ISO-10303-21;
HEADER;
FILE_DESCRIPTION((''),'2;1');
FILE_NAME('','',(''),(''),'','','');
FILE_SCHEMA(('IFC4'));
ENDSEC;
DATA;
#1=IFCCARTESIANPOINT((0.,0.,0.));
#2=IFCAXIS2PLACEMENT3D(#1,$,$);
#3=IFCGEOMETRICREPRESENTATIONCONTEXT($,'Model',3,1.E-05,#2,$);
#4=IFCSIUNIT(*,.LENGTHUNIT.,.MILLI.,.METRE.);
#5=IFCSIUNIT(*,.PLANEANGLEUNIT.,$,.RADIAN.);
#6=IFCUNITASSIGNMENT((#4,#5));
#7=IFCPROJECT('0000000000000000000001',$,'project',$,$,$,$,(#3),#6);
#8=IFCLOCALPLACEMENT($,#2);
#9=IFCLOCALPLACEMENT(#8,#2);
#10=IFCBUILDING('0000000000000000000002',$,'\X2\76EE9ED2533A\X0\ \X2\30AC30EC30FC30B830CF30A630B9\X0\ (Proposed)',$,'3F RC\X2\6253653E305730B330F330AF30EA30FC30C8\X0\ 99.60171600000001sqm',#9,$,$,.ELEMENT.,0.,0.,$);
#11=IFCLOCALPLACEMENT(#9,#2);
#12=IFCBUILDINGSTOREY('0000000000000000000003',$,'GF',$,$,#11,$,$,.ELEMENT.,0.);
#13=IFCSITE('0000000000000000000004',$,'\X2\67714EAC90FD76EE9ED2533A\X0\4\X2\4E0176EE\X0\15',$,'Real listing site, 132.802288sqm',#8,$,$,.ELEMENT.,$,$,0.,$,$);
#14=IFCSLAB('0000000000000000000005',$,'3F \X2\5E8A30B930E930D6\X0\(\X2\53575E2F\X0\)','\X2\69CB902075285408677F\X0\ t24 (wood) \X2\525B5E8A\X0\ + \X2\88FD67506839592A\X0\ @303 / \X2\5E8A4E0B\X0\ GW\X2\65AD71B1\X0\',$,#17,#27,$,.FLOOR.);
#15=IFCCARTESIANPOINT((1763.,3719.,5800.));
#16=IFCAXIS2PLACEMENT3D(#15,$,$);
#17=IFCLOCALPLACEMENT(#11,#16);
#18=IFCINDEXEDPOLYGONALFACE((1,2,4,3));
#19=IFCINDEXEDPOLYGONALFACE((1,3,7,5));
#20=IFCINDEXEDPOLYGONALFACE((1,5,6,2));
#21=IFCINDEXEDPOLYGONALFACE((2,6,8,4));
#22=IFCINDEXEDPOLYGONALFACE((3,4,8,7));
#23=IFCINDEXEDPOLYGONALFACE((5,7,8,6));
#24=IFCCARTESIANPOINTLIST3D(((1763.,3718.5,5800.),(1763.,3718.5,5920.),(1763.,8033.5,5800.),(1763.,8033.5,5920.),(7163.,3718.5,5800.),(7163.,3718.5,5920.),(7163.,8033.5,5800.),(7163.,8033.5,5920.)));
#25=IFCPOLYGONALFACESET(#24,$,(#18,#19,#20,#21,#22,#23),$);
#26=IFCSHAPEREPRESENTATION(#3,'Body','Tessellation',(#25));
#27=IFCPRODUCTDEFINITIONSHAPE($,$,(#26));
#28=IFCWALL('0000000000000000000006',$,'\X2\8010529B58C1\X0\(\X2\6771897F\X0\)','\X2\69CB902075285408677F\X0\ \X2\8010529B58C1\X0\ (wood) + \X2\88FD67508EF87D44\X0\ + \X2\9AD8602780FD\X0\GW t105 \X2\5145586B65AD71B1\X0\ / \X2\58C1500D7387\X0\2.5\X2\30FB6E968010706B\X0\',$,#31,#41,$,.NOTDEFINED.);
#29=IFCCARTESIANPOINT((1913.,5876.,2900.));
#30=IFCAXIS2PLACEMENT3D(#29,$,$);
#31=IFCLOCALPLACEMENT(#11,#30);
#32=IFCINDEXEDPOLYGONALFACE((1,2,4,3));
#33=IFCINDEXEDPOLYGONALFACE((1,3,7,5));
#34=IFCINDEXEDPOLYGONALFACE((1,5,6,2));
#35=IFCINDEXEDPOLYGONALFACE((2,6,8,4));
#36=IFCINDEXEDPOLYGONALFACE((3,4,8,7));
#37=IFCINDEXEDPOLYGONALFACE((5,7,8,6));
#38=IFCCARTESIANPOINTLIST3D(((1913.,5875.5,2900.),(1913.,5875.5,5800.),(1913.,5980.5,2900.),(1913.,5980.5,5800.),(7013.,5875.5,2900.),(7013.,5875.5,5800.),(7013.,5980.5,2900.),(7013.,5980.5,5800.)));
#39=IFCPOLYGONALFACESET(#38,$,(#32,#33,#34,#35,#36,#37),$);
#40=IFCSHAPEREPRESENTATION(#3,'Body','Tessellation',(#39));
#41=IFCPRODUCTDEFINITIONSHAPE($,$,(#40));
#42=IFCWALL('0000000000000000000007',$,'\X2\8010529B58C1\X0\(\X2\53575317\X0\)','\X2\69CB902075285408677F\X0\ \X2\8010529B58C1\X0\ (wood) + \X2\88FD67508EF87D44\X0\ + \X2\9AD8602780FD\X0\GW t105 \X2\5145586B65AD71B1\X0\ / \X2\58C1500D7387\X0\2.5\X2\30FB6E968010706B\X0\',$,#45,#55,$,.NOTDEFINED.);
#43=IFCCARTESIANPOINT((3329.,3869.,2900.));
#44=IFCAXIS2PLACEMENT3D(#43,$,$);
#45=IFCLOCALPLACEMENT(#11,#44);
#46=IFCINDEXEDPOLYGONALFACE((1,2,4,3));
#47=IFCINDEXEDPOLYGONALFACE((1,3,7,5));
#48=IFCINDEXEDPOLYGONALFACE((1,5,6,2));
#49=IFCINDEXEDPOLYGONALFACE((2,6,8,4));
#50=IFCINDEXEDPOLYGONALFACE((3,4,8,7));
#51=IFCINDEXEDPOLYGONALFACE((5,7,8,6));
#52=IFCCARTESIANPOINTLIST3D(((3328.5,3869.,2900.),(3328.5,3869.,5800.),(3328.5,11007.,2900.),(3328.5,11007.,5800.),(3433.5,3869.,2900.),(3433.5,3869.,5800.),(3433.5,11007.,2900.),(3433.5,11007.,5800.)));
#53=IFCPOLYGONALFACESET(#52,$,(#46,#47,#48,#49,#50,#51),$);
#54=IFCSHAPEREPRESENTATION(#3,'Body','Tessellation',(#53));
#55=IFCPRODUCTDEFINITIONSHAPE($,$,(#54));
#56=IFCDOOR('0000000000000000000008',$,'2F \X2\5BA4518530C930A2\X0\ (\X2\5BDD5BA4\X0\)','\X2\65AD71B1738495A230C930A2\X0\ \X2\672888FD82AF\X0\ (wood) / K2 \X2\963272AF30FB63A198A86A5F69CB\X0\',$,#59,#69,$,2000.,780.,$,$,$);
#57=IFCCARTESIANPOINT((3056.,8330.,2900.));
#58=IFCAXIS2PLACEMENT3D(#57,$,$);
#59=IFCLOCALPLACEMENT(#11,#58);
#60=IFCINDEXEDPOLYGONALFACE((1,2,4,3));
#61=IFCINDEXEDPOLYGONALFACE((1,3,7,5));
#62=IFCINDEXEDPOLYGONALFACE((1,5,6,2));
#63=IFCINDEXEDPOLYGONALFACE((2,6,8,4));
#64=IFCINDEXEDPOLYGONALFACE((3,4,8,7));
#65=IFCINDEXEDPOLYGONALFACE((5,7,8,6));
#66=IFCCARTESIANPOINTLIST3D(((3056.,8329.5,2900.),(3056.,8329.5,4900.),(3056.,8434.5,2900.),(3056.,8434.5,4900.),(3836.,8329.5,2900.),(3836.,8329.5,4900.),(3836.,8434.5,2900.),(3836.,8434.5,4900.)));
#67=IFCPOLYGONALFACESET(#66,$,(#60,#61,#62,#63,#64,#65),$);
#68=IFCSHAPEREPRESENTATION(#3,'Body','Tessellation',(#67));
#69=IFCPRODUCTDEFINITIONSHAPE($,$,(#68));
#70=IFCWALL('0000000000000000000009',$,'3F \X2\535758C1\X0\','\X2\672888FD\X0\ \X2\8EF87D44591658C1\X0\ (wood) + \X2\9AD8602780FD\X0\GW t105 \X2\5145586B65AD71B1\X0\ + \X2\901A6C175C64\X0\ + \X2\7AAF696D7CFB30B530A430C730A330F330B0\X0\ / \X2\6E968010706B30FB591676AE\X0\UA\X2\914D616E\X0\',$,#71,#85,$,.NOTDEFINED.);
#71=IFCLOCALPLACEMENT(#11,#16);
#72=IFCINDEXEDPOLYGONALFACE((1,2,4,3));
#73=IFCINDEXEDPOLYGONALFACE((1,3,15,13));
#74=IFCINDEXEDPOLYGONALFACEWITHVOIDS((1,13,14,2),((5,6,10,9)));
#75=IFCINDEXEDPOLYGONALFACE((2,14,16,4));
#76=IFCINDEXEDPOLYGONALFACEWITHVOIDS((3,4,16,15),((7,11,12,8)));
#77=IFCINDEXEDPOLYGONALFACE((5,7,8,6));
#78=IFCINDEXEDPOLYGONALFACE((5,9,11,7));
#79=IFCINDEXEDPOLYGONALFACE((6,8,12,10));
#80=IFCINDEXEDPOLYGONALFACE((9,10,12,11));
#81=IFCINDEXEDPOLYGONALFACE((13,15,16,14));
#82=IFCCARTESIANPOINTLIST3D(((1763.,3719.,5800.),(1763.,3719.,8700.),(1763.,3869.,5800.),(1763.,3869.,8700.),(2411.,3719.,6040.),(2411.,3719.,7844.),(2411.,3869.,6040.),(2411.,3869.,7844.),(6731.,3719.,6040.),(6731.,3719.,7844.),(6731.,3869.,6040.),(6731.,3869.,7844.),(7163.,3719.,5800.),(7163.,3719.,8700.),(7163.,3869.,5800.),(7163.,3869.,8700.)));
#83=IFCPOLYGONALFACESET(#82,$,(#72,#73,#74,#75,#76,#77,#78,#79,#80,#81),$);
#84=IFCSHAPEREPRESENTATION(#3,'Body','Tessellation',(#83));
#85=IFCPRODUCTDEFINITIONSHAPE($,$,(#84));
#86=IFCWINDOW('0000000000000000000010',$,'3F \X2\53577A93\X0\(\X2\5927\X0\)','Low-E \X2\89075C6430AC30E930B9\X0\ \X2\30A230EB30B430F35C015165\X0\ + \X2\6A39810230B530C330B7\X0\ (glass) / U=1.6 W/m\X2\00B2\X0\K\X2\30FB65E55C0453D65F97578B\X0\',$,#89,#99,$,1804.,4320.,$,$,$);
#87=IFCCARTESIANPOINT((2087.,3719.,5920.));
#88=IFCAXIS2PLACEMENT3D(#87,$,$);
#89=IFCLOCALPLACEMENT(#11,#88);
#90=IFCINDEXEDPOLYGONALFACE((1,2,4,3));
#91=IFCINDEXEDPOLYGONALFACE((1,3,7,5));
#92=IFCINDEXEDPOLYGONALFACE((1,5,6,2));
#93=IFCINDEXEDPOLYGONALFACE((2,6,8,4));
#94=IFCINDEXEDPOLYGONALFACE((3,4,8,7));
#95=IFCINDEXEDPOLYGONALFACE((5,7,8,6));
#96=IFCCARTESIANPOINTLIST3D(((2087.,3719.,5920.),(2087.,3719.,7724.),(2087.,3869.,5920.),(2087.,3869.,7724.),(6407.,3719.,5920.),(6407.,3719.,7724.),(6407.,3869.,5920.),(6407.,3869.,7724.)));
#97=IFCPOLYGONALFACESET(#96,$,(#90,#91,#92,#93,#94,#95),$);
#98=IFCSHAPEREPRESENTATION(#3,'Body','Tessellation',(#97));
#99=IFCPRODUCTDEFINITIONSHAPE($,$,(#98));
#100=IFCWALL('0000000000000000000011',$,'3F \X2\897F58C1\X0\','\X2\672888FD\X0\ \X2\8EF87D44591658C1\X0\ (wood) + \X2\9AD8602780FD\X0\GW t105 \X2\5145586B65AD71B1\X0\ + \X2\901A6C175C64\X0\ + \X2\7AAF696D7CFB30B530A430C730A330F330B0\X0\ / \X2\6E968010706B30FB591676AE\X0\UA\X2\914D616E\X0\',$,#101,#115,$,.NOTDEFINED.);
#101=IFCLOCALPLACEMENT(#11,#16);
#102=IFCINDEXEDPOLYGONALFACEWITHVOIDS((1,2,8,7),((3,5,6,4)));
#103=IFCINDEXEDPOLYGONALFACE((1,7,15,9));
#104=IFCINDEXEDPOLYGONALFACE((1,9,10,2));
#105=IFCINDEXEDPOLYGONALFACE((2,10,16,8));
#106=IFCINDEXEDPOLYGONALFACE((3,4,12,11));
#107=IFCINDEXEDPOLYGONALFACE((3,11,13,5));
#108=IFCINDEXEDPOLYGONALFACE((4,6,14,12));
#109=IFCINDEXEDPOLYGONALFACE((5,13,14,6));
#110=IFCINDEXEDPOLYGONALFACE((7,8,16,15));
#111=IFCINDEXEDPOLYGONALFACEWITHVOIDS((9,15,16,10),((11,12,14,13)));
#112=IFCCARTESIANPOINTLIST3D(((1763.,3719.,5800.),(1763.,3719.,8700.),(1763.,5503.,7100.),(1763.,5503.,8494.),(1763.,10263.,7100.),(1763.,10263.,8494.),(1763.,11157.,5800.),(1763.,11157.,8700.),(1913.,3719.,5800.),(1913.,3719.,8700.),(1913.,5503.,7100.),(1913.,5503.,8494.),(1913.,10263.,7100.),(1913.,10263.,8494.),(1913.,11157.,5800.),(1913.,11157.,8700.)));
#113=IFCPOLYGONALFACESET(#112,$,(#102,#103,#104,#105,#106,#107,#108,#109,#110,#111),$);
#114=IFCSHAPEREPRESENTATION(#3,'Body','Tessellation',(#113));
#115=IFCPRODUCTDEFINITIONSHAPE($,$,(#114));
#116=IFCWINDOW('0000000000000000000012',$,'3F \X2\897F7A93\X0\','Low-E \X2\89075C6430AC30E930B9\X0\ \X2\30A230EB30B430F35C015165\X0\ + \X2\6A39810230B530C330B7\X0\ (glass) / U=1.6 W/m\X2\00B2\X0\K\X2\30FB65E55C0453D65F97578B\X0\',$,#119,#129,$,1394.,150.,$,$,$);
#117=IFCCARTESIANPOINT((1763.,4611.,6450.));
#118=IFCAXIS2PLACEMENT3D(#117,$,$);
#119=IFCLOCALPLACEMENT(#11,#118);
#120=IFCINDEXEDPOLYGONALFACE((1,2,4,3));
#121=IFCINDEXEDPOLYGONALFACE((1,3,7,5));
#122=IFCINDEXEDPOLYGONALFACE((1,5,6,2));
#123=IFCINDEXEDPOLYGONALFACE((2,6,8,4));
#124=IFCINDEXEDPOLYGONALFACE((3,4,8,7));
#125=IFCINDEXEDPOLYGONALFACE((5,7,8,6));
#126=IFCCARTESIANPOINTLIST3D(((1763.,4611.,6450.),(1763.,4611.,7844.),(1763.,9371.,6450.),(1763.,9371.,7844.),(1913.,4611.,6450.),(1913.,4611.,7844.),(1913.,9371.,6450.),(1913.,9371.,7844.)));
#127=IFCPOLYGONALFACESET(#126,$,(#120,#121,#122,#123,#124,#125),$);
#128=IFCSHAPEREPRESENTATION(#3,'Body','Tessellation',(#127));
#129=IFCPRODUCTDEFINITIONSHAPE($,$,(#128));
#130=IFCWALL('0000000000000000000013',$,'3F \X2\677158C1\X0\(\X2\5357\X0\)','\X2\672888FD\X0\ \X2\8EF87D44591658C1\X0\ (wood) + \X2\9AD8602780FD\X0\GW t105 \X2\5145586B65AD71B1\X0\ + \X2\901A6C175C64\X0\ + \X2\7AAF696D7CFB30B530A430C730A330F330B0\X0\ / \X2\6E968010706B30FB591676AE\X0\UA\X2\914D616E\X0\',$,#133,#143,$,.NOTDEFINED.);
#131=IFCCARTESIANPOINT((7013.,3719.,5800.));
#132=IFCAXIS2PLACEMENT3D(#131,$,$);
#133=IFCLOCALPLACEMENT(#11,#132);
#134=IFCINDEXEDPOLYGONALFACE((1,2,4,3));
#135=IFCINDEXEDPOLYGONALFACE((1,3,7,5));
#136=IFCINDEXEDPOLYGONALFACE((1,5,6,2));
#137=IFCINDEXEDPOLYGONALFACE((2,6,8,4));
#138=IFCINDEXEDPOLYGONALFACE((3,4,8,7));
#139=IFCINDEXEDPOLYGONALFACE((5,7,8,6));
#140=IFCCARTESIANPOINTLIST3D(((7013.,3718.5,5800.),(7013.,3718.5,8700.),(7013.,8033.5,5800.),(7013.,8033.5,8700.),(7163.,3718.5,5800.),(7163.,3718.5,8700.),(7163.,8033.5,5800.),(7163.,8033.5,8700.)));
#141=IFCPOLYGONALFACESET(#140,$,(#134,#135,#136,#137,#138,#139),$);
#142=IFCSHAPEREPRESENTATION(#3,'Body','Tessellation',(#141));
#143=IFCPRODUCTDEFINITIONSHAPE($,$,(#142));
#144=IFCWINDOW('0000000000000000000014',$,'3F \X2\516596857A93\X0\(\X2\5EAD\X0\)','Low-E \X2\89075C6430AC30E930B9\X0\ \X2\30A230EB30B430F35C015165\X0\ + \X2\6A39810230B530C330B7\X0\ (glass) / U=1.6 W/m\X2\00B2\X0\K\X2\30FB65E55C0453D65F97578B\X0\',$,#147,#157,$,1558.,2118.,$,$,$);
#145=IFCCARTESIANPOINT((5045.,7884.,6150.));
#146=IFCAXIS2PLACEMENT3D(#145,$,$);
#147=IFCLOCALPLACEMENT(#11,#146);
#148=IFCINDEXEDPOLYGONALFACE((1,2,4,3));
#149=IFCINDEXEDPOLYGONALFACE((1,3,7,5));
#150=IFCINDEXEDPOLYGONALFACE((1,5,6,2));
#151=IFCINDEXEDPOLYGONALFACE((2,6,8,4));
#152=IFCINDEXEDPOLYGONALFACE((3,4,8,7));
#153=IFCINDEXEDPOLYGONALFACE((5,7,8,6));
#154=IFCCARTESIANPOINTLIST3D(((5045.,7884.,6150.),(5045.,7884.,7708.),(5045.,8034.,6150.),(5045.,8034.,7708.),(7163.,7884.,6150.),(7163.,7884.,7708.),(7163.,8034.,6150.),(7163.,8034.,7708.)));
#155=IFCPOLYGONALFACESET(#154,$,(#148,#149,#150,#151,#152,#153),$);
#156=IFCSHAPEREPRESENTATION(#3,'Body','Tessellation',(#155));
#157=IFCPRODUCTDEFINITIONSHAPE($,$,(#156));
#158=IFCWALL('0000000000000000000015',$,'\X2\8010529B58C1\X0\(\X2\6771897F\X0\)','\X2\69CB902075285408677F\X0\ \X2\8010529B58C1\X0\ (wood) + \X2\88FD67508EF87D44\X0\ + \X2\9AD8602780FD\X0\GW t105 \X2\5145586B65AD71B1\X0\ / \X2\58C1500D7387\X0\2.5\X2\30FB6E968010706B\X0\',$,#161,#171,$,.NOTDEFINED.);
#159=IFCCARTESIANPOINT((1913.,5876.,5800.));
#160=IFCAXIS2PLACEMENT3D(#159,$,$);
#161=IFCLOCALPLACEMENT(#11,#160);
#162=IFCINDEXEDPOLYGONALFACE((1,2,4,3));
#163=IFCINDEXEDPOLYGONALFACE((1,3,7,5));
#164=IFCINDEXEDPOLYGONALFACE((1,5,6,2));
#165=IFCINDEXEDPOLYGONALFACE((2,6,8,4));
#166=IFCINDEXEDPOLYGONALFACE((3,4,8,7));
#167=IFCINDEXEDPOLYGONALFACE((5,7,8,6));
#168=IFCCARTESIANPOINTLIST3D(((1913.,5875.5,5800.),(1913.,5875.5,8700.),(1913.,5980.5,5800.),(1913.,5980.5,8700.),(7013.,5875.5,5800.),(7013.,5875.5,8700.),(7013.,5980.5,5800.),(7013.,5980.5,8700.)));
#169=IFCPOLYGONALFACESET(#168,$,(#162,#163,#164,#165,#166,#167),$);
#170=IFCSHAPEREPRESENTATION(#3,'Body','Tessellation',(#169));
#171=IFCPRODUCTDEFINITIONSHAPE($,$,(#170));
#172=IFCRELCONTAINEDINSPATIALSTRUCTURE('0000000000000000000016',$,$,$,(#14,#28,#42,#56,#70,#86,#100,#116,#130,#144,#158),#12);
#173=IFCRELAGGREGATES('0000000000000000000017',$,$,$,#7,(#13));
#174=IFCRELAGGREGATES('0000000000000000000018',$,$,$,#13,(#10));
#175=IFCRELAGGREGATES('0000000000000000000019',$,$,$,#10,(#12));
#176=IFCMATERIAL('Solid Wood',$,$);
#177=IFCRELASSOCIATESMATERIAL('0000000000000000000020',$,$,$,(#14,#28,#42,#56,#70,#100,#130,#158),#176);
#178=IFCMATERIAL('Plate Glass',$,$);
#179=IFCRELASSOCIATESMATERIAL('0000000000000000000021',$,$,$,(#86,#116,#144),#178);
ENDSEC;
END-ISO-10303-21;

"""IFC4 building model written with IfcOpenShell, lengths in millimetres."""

from ifc_helpers import new_model, si_unit, frame, frame_2d, origin, place, context, project, spatial, rectangle, extrude, material, element, fill, save


model = new_model("IFC4")

# Units and contexts
model_context = context("Model", 3, precision=1e-05, world=origin())
ifc_project = project(units=[si_unit("LENGTHUNIT", "METRE", prefix="MILLI"), si_unit("PLANEANGLEUNIT", "RADIAN")], contexts=[model_context])

# Site, building, storey
site_placement = place(None, origin())
site = spatial("IfcSite", under=ifc_project, at=site_placement, Name="東京都目黒区4丁目15", ObjectType="Real listing site, 132.802288sqm", CompositionType="ELEMENT", RefElevation=0.0)
building_placement = place(site_placement, origin())
building = spatial("IfcBuilding", under=site, at=building_placement, Name="目黒区 ガレージハウス (Proposed)", ObjectType="3F RC打放しコンクリート 99.60171600000001sqm", CompositionType="ELEMENT", ElevationOfRefHeight=0.0, ElevationOfTerrain=0.0)
storey_placement = place(building_placement, origin())
storey = spatial("IfcBuildingStorey", under=building, at=storey_placement, Name="GF", CompositionType="ELEMENT", Elevation=0.0)

# Slab
ifc_material_1 = material(Name="Solid Wood")
slab_placement = place(storey_placement, frame((1763.0, 3719.0, 5800.0)))
element("IfcSlab", 1, at=slab_placement, inside=storey, material=ifc_material_1, Name="3F 床スラブ(南帯)", Description="構造用合板 t24 (wood) 剛床 + 製材根太 @303 / 床下 GW断熱", PredefinedType="FLOOR", context=model_context, shape_type="SweptSolid", body=[
    extrude(rectangle(XDim=5400.0, YDim=4315.0, at=frame_2d((2700.0, 2157.0))), frame((1763.0, 3719.0, 5800.0)), (0.0, 0.0, 1.0), 120.0),
])

# Wall
wall_1_placement = place(storey_placement, frame((1913.0, 5876.0, 2900.0)))
element("IfcWall", 2, at=wall_1_placement, inside=storey, material=ifc_material_1, Name="耐力壁(東西)", Description="構造用合板 耐力壁 (wood) + 製材軸組 + 高性能GW t105 充填断熱 / 壁倍率2.5・準耐火", PredefinedType="NOTDEFINED", context=model_context, shape_type="SweptSolid", body=[
    extrude(rectangle(XDim=5100.0, YDim=105.0, at=frame_2d((2550.0, 52.0))), frame((1913.0, 5876.0, 2900.0)), (0.0, 0.0, 1.0), 2900.0),
])

# Wall, opening, door
wall_2_placement = place(storey_placement, frame((3329.0, 3869.0, 2900.0)))
wall_2 = element("IfcWall", 3, at=wall_2_placement, inside=storey, material=ifc_material_1, Name="耐力壁(南北)", Description="構造用合板 耐力壁 (wood) + 製材軸組 + 高性能GW t105 充填断熱 / 壁倍率2.5・準耐火", PredefinedType="NOTDEFINED", context=model_context, shape_type="SweptSolid", body=[
    extrude(rectangle(XDim=105.0, YDim=7138.0, at=frame_2d((52.0, 3569.0))), frame((3329.0, 3869.0, 2900.0)), (0.0, 0.0, 1.0), 2900.0),
])
opening_1_placement = place(storey_placement, frame((3056.0, 8330.0, 2900.0)))
opening_1 = element("IfcOpeningElement", 4, at=opening_1_placement, cuts=wall_2, PredefinedType="NOTDEFINED", context=model_context, shape_type="SweptSolid", body=[
    extrude(rectangle(XDim=780.0, YDim=105.0, at=frame_2d((390.0, 52.0))), frame((3056.0, 8330.0, 2900.0)), (0.0, 0.0, 1.0), 2000.0),
])
door_1_placement = place(storey_placement, frame((3056.0, 8330.0, 2900.0)))
door_1 = element("IfcDoor", 5, at=door_1_placement, inside=storey, material=ifc_material_1, Name="2F 室内ドア (寝室)", Description="断熱玄関ドア 木製芯 (wood) / K2 防犯・採風機構", OverallHeight=2000.0, OverallWidth=780.0, context=model_context, shape_type="SweptSolid", body=[
    extrude(rectangle(XDim=780.0, YDim=105.0, at=frame_2d((390.0, 52.0))), frame((3056.0, 8330.0, 2900.0)), (0.0, 0.0, 1.0), 2000.0),
])
fill(opening_1, door_1)

# Walls, openings, windows
wall_3_placement = place(storey_placement, frame((1763.0, 3719.0, 5800.0)))
wall_3 = element("IfcWall", 6, at=wall_3_placement, inside=storey, material=ifc_material_1, Name="3F 南壁", Description="木製 軸組外壁 (wood) + 高性能GW t105 充填断熱 + 通気層 + 窯業系サイディング / 準耐火・外皮UA配慮", PredefinedType="NOTDEFINED", context=model_context, shape_type="SweptSolid", body=[
    extrude(rectangle(XDim=5400.0, YDim=150.0, at=frame_2d((2700.0, 75.0))), frame((1763.0, 3719.0, 5800.0)), (0.0, 0.0, 1.0), 2900.0),
])
opening_2_placement = place(storey_placement, frame((2087.0, 3719.0, 5920.0)))
opening_2 = element("IfcOpeningElement", 7, at=opening_2_placement, cuts=wall_3, PredefinedType="NOTDEFINED", context=model_context, shape_type="SweptSolid", body=[
    extrude(rectangle(XDim=4320.0, YDim=150.0, at=frame_2d((2160.0, 75.0))), frame((2087.0, 3719.0, 5920.0)), (0.0, 0.0, 1.0), 1804.0),
])
ifc_material_2 = material(Name="Plate Glass")
window_1_placement = place(storey_placement, frame((2087.0, 3719.0, 5920.0)))
window_1 = element("IfcWindow", 8, at=window_1_placement, inside=storey, material=ifc_material_2, Name="3F 南窓(大)", Description="Low-E 複層ガラス アルゴン封入 + 樹脂サッシ (glass) / U=1.6 W/m²K・日射取得型", OverallHeight=1804.0, OverallWidth=4320.0, context=model_context, shape_type="SweptSolid", body=[
    extrude(rectangle(XDim=4320.0, YDim=150.0, at=frame_2d((2160.0, 75.0))), frame((2087.0, 3719.0, 5920.0)), (0.0, 0.0, 1.0), 1804.0),
])
fill(opening_2, window_1)
wall_4_placement = place(storey_placement, frame((1763.0, 3719.0, 5800.0)))
wall_4 = element("IfcWall", 9, at=wall_4_placement, inside=storey, material=ifc_material_1, Name="3F 西壁", Description="木製 軸組外壁 (wood) + 高性能GW t105 充填断熱 + 通気層 + 窯業系サイディング / 準耐火・外皮UA配慮", PredefinedType="NOTDEFINED", context=model_context, shape_type="SweptSolid", body=[
    extrude(rectangle(XDim=150.0, YDim=7438.0, at=frame_2d((75.0, 3719.0))), frame((1763.0, 3719.0, 5800.0)), (0.0, 0.0, 1.0), 2900.0),
])
opening_3_placement = place(storey_placement, frame((1763.0, 4611.0, 6450.0)))
opening_3 = element("IfcOpeningElement", 10, at=opening_3_placement, cuts=wall_4, PredefinedType="NOTDEFINED", context=model_context, shape_type="SweptSolid", body=[
    extrude(rectangle(XDim=150.0, YDim=4760.0, at=frame_2d((75.0, 2380.0))), frame((1763.0, 4611.0, 6450.0)), (0.0, 0.0, 1.0), 1394.0),
])
window_2_placement = place(storey_placement, frame((1763.0, 4611.0, 6450.0)))
window_2 = element("IfcWindow", 11, at=window_2_placement, inside=storey, material=ifc_material_2, Name="3F 西窓", Description="Low-E 複層ガラス アルゴン封入 + 樹脂サッシ (glass) / U=1.6 W/m²K・日射取得型", OverallHeight=1394.0, OverallWidth=150.0, context=model_context, shape_type="SweptSolid", body=[
    extrude(rectangle(XDim=150.0, YDim=4760.0, at=frame_2d((75.0, 2380.0))), frame((1763.0, 4611.0, 6450.0)), (0.0, 0.0, 1.0), 1394.0),
])
fill(opening_3, window_2)
wall_5_placement = place(storey_placement, frame((7013.0, 3719.0, 5800.0)))
wall_5 = element("IfcWall", 12, at=wall_5_placement, inside=storey, material=ifc_material_1, Name="3F 東壁(南)", Description="木製 軸組外壁 (wood) + 高性能GW t105 充填断熱 + 通気層 + 窯業系サイディング / 準耐火・外皮UA配慮", PredefinedType="NOTDEFINED", context=model_context, shape_type="SweptSolid", body=[
    extrude(rectangle(XDim=150.0, YDim=4315.0, at=frame_2d((75.0, 2157.0))), frame((7013.0, 3719.0, 5800.0)), (0.0, 0.0, 1.0), 2900.0),
])
opening_4_placement = place(storey_placement, frame((5045.0, 7884.0, 6150.0)))
opening_4 = element("IfcOpeningElement", 13, at=opening_4_placement, cuts=wall_5, PredefinedType="NOTDEFINED", context=model_context, shape_type="SweptSolid", body=[
    extrude(rectangle(XDim=2118.0, YDim=150.0, at=frame_2d((1059.0, 75.0))), frame((5045.0, 7884.0, 6150.0)), (0.0, 0.0, 1.0), 1558.0),
])
window_3_placement = place(storey_placement, frame((5045.0, 7884.0, 6150.0)))
window_3 = element("IfcWindow", 14, at=window_3_placement, inside=storey, material=ifc_material_2, Name="3F 入隅窓(庭)", Description="Low-E 複層ガラス アルゴン封入 + 樹脂サッシ (glass) / U=1.6 W/m²K・日射取得型", OverallHeight=1558.0, OverallWidth=2118.0, context=model_context, shape_type="SweptSolid", body=[
    extrude(rectangle(XDim=2118.0, YDim=150.0, at=frame_2d((1059.0, 75.0))), frame((5045.0, 7884.0, 6150.0)), (0.0, 0.0, 1.0), 1558.0),
])
fill(opening_4, window_3)

# Wall
wall_6_placement = place(storey_placement, frame((1913.0, 5876.0, 5800.0)))
element("IfcWall", 15, at=wall_6_placement, inside=storey, material=ifc_material_1, Name="耐力壁(東西)", Description="構造用合板 耐力壁 (wood) + 製材軸組 + 高性能GW t105 充填断熱 / 壁倍率2.5・準耐火", PredefinedType="NOTDEFINED", context=model_context, shape_type="SweptSolid", body=[
    extrude(rectangle(XDim=5100.0, YDim=105.0, at=frame_2d((2550.0, 52.0))), frame((1913.0, 5876.0, 5800.0)), (0.0, 0.0, 1.0), 2900.0),
])

save(model, "model.ifc")
